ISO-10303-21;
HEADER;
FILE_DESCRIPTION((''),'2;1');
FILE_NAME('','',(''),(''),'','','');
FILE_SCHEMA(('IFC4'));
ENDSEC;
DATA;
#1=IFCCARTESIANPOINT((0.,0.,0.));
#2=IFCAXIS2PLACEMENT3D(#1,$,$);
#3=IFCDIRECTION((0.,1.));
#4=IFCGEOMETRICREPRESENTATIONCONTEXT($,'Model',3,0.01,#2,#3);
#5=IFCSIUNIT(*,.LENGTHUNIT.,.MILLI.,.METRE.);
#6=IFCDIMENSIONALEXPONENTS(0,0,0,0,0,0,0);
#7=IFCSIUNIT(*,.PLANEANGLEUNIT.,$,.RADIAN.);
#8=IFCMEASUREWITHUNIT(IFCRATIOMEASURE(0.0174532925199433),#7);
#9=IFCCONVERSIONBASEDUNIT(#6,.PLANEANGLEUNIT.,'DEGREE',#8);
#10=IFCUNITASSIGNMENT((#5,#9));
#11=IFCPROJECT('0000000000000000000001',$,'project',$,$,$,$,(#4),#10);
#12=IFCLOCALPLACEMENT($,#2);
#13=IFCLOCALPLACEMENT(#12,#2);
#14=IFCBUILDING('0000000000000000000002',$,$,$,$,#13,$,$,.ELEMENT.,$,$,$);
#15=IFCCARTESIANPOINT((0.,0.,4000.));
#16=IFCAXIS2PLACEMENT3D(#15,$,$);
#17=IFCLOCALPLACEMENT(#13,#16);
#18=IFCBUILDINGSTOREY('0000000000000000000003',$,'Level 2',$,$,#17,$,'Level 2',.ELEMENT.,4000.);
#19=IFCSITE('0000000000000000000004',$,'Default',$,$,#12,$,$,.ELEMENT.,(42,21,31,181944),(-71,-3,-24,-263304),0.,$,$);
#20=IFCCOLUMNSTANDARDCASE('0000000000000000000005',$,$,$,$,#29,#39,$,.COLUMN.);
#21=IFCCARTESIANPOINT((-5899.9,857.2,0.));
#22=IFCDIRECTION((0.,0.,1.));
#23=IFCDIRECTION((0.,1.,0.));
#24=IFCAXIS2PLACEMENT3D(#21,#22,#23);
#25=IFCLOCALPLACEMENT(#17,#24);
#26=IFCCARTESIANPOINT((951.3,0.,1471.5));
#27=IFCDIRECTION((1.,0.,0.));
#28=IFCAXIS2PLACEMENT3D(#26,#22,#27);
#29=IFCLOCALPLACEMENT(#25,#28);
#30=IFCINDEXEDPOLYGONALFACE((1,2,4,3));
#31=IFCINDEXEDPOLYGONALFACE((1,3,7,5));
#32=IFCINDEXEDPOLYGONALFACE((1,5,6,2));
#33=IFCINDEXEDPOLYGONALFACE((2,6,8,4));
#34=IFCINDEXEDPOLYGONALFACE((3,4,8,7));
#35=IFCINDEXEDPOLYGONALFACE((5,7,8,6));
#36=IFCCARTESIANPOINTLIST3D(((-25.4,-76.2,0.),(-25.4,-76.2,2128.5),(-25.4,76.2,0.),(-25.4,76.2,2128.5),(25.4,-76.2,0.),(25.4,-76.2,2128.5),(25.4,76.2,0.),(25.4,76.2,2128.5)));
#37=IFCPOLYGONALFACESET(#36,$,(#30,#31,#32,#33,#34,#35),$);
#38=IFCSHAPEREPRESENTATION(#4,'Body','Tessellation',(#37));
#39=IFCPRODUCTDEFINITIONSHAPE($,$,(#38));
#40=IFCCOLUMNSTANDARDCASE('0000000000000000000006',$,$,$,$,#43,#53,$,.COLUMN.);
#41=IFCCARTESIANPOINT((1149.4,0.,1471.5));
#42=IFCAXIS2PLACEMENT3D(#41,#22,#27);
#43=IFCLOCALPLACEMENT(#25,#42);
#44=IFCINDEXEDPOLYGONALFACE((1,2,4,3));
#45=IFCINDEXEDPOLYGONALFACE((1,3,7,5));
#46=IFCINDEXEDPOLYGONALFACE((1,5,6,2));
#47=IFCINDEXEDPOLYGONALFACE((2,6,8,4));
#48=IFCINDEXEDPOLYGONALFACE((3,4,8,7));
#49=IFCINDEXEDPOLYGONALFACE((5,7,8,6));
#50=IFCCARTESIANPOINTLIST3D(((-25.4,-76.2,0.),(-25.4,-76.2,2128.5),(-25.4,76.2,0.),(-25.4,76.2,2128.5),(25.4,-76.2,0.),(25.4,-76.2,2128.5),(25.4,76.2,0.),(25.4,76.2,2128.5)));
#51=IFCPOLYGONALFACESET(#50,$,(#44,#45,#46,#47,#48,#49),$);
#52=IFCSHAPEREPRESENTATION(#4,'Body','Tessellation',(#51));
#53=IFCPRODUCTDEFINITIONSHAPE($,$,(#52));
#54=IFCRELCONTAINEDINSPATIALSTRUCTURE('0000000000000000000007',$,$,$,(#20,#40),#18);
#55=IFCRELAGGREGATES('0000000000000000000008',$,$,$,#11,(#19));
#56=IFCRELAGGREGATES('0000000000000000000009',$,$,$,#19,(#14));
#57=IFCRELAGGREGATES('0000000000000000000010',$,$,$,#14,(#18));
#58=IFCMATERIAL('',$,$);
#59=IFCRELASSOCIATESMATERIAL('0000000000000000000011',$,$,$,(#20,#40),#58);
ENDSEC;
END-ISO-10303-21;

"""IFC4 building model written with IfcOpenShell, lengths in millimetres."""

from ifc_helpers import new_model, entity, si_unit, converted_unit, direction, frame, origin, place, context, project, spatial, rectangle, extrude, material, element, save


model = new_model("IFC4")

# Units and contexts
model_context = context("Model", 3, precision=0.01, world=origin(), true_north=direction((0.0, 1.0)))
ifc_project = project(units=[si_unit("LENGTHUNIT", "METRE", prefix="MILLI"), converted_unit("PLANEANGLEUNIT", "DEGREE", entity("IfcRatioMeasure", 0.0174532925199433), si_unit("PLANEANGLEUNIT", "RADIAN"), dimensions=[0, 0, 0, 0, 0, 0, 0])], contexts=[model_context])

# Site, building, storey
site_placement = place(None, origin())
site = spatial("IfcSite", under=ifc_project, at=site_placement, Name="Default", CompositionType="ELEMENT", RefLatitude=(42, 21, 31, 181944), RefLongitude=(-71, -3, -24, -263304), RefElevation=0.0)
building_placement = place(site_placement, origin())
building = spatial("IfcBuilding", under=site, at=building_placement, CompositionType="ELEMENT")
storey_placement = place(building_placement, frame((0.0, 0.0, 4000.0)))
storey = spatial("IfcBuildingStorey", under=building, at=storey_placement, Name="Level 2", LongName="Level 2", CompositionType="ELEMENT", Elevation=4000.0)

# Columns
ifc_material_1 = material(Name="")
placement_1 = place(storey_placement, frame((-5899.9, 857.2, 0.0), z_axis=(0.0, 0.0, 1.0), x_axis=(0.0, 1.0, 0.0)))
for number, where, z_axis, x_axis in (
    (1, (951.3, 0.0, 1471.5), (0.0, 0.0, 1.0), (1.0, 0.0, 0.0)),
    (2, (1149.4, 0.0, 1471.5), (0.0, 0.0, 1.0), (1.0, 0.0, 0.0)),
):
    element("IfcColumnStandardCase", number, at=place(placement_1, frame(where, z_axis=z_axis, x_axis=x_axis)), inside=storey, material=ifc_material_1, PredefinedType="COLUMN", context=model_context, shape_type="SweptSolid", body=[
        extrude(rectangle(XDim=50.8, YDim=152.4), origin(), (0.0, 0.0, 1.0), 2128.5),
    ])

save(model, "model.ifc")
